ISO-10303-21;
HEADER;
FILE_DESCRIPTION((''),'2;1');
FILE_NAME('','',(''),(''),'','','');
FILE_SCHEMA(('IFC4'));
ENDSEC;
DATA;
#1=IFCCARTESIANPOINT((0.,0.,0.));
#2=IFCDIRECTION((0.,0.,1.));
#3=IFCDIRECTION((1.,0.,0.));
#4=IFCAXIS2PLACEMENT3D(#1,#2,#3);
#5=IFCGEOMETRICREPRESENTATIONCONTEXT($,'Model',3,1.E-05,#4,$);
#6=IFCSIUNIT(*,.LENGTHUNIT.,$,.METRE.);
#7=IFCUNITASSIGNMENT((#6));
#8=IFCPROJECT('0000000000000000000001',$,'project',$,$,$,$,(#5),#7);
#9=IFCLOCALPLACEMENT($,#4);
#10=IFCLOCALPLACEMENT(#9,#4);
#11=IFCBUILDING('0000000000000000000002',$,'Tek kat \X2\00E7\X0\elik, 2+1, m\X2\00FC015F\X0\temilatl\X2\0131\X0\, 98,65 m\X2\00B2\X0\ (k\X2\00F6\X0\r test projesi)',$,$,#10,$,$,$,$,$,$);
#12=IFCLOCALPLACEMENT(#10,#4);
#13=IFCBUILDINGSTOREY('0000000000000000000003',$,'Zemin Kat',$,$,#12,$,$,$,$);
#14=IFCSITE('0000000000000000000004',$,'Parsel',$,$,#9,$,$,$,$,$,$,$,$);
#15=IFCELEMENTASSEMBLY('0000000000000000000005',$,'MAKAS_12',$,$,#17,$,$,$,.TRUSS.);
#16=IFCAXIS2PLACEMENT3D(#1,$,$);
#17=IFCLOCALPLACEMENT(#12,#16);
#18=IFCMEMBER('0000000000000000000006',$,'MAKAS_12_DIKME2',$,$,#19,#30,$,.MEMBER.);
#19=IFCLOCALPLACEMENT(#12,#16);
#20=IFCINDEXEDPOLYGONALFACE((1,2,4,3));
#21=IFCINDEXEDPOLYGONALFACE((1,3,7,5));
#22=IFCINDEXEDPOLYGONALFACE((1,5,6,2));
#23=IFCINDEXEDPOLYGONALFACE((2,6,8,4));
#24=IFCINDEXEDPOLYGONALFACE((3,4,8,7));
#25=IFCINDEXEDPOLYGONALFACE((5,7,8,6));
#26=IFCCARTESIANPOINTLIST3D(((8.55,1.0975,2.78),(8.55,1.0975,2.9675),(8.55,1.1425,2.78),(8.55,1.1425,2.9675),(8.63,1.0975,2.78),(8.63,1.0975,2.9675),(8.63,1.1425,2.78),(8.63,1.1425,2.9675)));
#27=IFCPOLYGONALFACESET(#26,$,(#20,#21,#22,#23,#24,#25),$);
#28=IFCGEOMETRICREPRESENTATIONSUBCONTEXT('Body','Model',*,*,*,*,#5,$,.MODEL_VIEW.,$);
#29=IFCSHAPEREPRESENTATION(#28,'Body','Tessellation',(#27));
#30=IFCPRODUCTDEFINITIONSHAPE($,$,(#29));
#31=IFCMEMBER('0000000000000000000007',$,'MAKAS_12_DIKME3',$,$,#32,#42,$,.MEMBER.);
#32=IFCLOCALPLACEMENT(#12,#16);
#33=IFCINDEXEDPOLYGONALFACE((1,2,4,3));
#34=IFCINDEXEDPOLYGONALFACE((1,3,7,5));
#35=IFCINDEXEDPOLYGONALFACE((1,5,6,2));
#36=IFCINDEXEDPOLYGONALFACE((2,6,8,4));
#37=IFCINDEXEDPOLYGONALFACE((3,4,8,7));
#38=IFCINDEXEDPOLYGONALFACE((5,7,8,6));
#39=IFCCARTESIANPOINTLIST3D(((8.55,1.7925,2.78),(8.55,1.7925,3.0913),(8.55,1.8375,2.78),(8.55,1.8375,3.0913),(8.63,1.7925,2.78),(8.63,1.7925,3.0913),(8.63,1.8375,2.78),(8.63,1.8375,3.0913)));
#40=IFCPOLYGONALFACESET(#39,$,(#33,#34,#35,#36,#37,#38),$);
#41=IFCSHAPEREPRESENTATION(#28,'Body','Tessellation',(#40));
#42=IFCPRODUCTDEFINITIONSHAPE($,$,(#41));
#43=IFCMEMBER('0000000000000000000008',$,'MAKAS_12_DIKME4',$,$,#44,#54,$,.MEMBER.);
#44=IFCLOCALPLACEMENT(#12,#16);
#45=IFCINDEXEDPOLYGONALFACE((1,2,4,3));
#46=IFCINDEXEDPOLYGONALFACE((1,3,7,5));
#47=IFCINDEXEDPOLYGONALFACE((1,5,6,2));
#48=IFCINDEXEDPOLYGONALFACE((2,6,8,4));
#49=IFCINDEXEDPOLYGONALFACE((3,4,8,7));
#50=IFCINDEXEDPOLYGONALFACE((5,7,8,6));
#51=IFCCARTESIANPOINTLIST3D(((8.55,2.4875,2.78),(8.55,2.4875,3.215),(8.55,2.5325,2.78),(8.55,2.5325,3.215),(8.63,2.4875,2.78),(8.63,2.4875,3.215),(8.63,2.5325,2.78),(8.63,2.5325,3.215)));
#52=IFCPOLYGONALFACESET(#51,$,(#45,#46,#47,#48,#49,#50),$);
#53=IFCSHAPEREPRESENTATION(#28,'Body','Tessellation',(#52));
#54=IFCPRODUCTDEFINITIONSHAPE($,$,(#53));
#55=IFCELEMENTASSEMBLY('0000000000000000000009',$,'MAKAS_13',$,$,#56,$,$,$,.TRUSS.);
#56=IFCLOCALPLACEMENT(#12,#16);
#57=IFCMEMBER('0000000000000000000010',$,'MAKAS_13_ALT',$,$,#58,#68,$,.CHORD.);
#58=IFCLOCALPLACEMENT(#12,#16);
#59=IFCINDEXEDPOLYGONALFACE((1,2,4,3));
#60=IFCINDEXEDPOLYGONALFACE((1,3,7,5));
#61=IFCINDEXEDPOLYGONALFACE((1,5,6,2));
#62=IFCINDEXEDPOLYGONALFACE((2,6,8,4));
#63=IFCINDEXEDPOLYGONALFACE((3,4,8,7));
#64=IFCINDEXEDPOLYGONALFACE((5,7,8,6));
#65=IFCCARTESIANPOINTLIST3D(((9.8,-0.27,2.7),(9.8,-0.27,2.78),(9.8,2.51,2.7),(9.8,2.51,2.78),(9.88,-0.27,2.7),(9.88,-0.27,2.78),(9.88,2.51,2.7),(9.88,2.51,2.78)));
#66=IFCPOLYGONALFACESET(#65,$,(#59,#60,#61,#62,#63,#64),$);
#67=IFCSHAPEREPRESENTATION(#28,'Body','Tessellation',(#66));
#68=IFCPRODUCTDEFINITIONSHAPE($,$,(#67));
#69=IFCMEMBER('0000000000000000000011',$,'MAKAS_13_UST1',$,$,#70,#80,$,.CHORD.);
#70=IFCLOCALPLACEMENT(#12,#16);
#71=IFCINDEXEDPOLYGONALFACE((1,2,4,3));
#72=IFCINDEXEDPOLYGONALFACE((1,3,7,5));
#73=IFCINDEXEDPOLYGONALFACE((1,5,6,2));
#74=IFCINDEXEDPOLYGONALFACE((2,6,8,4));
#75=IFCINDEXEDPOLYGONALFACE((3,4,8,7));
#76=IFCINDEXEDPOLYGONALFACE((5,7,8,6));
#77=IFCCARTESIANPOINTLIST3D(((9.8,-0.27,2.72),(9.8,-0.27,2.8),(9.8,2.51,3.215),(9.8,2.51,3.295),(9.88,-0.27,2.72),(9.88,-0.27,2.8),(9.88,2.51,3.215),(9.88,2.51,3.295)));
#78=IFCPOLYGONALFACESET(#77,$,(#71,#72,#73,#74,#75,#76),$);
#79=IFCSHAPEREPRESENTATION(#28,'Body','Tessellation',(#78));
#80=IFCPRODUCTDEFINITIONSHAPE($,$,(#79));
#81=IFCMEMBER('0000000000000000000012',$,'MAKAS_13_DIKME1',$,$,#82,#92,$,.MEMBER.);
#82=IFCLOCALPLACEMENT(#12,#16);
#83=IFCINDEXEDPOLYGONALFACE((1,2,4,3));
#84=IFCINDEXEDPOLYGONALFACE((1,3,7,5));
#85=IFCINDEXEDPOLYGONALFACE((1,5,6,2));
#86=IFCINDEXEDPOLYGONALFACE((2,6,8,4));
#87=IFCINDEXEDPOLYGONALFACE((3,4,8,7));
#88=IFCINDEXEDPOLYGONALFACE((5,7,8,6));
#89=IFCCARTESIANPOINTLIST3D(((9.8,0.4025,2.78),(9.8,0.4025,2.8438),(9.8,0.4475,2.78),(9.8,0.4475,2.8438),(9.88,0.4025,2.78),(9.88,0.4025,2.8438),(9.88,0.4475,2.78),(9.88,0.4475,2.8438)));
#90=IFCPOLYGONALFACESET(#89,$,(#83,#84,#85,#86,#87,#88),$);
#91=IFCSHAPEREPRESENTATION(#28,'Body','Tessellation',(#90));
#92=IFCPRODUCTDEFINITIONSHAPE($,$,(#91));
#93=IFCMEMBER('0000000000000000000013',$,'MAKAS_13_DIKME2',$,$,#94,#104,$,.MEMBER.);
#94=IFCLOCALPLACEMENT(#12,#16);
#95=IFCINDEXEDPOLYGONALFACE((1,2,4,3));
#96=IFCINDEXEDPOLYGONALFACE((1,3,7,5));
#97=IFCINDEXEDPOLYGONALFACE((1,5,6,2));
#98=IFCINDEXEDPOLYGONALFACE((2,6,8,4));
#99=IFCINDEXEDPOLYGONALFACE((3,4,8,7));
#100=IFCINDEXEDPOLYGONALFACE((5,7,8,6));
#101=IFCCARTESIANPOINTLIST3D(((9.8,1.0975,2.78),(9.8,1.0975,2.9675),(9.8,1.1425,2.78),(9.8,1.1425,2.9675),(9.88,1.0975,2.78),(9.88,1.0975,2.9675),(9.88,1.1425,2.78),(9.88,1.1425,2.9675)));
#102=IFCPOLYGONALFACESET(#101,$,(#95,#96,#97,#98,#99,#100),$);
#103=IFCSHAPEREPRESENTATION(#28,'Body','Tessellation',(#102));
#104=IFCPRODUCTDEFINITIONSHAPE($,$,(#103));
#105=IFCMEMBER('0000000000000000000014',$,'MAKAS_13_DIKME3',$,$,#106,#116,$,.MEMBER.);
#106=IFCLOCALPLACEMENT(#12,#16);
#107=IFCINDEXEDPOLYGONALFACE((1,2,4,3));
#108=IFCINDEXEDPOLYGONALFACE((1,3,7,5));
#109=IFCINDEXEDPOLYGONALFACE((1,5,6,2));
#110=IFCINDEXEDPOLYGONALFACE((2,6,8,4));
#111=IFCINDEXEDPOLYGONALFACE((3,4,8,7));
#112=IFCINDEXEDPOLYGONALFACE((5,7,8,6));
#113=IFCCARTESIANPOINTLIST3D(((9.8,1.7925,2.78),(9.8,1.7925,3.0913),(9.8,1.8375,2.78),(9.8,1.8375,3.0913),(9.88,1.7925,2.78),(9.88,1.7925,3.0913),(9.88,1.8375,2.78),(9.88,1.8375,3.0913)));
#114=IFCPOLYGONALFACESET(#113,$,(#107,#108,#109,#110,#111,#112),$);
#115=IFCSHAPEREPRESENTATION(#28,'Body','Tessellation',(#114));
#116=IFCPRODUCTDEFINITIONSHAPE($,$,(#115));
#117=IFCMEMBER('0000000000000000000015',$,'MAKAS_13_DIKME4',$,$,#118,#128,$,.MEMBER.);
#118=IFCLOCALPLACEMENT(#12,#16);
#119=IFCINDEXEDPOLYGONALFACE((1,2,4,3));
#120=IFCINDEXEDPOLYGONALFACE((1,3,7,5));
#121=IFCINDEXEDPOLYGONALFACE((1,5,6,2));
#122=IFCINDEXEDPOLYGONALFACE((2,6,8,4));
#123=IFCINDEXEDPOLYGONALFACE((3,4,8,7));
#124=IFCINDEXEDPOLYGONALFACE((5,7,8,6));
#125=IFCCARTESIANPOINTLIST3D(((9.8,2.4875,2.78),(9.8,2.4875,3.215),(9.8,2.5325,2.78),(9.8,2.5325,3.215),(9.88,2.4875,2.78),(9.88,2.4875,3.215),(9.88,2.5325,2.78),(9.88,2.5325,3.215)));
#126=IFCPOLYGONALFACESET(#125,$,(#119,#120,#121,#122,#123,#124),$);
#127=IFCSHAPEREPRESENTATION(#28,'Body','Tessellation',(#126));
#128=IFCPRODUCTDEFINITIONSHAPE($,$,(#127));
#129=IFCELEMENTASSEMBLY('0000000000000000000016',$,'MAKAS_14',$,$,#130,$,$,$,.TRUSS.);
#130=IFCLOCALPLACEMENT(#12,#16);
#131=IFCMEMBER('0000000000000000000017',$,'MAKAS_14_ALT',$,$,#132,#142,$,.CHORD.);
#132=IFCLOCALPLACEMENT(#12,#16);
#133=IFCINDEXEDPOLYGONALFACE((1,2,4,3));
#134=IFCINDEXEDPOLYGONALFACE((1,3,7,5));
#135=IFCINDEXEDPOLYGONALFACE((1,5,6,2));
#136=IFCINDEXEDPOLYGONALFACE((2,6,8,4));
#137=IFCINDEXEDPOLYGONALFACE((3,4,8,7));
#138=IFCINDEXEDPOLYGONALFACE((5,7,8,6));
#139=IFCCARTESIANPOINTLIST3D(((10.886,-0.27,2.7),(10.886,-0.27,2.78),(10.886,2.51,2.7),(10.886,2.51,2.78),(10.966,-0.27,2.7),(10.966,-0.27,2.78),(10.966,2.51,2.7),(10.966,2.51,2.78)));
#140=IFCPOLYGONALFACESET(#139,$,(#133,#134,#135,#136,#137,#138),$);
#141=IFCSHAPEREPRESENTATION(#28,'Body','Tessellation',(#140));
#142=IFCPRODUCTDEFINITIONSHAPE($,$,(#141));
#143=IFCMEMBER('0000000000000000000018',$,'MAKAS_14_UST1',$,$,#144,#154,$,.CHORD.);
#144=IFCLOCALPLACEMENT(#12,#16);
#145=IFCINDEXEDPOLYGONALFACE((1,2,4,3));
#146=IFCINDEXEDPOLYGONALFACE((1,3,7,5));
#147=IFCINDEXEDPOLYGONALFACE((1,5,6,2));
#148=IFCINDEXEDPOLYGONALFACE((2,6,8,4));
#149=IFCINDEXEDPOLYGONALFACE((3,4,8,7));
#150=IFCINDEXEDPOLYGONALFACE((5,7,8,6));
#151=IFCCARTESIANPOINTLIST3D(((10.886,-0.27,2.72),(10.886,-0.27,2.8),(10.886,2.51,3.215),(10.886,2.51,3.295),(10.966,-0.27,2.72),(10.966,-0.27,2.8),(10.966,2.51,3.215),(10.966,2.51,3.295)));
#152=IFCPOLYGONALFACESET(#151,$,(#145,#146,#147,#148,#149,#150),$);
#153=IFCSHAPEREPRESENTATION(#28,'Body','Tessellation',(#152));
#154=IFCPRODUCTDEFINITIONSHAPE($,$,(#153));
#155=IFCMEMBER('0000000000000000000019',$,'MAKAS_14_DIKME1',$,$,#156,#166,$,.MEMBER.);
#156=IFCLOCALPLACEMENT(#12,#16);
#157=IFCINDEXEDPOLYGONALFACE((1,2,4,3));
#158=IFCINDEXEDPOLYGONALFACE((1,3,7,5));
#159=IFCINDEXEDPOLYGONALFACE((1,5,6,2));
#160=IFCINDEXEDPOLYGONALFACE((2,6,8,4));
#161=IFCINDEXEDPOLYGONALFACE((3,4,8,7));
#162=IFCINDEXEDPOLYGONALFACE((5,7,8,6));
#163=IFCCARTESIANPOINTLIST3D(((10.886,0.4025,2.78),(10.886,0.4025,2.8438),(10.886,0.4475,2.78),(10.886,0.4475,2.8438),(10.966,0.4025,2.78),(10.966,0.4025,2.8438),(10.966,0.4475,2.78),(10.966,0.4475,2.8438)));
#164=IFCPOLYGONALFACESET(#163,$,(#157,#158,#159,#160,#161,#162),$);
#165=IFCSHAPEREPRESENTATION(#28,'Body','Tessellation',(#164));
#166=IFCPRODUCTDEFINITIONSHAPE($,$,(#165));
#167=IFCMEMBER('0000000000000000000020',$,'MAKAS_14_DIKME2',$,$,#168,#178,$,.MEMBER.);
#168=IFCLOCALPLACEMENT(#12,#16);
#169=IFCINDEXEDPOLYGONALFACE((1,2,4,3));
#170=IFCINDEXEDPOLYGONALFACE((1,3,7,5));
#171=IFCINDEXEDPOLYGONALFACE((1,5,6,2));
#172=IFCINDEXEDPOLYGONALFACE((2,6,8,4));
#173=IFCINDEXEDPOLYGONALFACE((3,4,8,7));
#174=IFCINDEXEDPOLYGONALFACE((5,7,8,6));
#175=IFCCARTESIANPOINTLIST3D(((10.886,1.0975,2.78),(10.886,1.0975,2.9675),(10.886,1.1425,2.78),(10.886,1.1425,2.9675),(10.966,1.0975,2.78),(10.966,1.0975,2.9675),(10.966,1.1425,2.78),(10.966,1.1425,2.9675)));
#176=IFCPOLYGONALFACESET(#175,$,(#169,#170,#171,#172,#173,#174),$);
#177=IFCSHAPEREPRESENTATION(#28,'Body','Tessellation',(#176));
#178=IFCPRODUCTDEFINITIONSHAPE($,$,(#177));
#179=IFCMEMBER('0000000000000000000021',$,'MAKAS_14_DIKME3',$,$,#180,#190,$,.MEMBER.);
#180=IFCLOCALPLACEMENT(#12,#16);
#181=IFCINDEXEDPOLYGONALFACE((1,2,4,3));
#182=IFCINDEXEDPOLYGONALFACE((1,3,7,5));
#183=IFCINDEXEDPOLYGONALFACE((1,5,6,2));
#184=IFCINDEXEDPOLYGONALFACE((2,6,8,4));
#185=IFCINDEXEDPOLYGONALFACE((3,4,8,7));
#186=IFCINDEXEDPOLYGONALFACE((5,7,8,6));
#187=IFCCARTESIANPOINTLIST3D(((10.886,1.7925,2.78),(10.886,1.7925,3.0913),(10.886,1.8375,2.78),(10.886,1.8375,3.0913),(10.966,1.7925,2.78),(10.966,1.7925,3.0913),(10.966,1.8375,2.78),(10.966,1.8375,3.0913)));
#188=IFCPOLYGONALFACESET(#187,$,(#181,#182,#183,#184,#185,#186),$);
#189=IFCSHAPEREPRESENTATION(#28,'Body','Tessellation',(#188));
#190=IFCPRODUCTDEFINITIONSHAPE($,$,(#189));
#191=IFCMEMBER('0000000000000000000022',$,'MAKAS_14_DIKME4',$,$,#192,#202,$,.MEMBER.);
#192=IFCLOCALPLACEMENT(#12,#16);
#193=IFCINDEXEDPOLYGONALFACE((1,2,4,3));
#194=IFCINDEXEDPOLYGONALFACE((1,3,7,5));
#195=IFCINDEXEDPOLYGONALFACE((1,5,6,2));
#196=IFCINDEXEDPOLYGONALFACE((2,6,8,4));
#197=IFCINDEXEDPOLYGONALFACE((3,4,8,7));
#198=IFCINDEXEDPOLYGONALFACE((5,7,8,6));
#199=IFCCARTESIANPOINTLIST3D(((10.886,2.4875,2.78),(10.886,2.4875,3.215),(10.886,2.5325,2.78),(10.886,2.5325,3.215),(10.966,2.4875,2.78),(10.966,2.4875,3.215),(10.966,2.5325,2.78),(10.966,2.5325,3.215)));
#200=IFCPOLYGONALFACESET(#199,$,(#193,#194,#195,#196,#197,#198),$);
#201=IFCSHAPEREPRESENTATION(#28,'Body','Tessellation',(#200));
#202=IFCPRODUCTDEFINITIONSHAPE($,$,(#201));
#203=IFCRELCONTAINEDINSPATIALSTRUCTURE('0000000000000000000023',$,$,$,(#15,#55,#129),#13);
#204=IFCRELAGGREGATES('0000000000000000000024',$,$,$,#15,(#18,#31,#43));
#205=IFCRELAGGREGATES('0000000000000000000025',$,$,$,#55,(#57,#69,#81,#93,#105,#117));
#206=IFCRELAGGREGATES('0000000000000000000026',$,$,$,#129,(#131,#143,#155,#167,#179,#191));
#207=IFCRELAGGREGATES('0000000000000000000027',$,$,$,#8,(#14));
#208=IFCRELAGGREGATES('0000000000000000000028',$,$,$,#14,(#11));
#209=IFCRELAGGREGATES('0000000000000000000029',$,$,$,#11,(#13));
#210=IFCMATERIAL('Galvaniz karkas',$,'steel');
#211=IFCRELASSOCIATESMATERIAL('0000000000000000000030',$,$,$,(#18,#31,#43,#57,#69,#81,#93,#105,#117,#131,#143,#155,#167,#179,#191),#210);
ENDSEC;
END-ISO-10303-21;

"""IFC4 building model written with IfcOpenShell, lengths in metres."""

from ifc_helpers import new_model, si_unit, frame, origin_with_axes, place, context, subcontext, project, spatial, line, indexed_curve, outline, extrude, material, element, aggregate, save


model = new_model("IFC4")

# Units and contexts
model_context = context("Model", 3, precision=1e-05, world=origin_with_axes())
body_context = subcontext(model_context, "Body", "Model", "MODEL_VIEW")
ifc_project = project(units=[si_unit("LENGTHUNIT", "METRE")], contexts=[model_context])

# Site, building, storey
site_placement = place(None, origin_with_axes())
site = spatial("IfcSite", under=ifc_project, at=site_placement, Name="Parsel")
building_placement = place(site_placement, origin_with_axes())
building = spatial("IfcBuilding", under=site, at=building_placement, Name="Tek kat çelik, 2+1, müştemilatlı, 98,65 m² (kör test projesi)")
storey_placement = place(building_placement, origin_with_axes())
storey = spatial("IfcBuildingStorey", under=building, at=storey_placement, Name="Zemin Kat")

# Element assemblies, members
ifc_material = material(Name="Galvaniz karkas", Category="steel")
assembly_1_placement = place(storey_placement, origin_with_axes())
assembly_1 = element("IfcElementAssembly", 1, at=assembly_1_placement, inside=storey, Name="MAKAS_12", PredefinedType="TRUSS")
member_1_placement = place(assembly_1_placement, origin_with_axes())
member_1 = element("IfcMember", 2, at=member_1_placement, material=ifc_material, Name="MAKAS_12_DIKME2", PredefinedType="MEMBER", context=body_context, shape_type="SweptSolid", body=[
    extrude(outline(indexed_curve([(1.0975, 2.78), (1.1425, 2.78), (1.1425, 2.9675), (1.0975, 2.9675)], segments=[line(1, 2, 3, 4, 1)])), frame((8.55, 0.0, 0.0), z_axis=(1.0, 0.0, 0.0), x_axis=(0.0, 1.0, 0.0)), (0.0, 0.0, 1.0), 0.08),
])
member_2_placement = place(assembly_1_placement, origin_with_axes())
member_2 = element("IfcMember", 3, at=member_2_placement, material=ifc_material, Name="MAKAS_12_DIKME3", PredefinedType="MEMBER", context=body_context, shape_type="SweptSolid", body=[
    extrude(outline(indexed_curve([(1.7925, 2.78), (1.8375, 2.78), (1.8375, 3.0913), (1.7925, 3.0913)], segments=[line(1, 2, 3, 4, 1)])), frame((8.55, 0.0, 0.0), z_axis=(1.0, 0.0, 0.0), x_axis=(0.0, 1.0, 0.0)), (0.0, 0.0, 1.0), 0.08),
])
member_3_placement = place(assembly_1_placement, origin_with_axes())
member_3 = element("IfcMember", 4, at=member_3_placement, material=ifc_material, Name="MAKAS_12_DIKME4", PredefinedType="MEMBER", context=body_context, shape_type="SweptSolid", body=[
    extrude(outline(indexed_curve([(2.4875, 2.78), (2.5325, 2.78), (2.5325, 3.215), (2.4875, 3.215)], segments=[line(1, 2, 3, 4, 1)])), frame((8.55, 0.0, 0.0), z_axis=(1.0, 0.0, 0.0), x_axis=(0.0, 1.0, 0.0)), (0.0, 0.0, 1.0), 0.08),
])
aggregate(assembly_1, [member_1, member_2, member_3])
assembly_2_placement = place(storey_placement, origin_with_axes())
assembly_2 = element("IfcElementAssembly", 5, at=assembly_2_placement, inside=storey, Name="MAKAS_13", PredefinedType="TRUSS")
member_4_placement = place(assembly_2_placement, origin_with_axes())
member_4 = element("IfcMember", 6, at=member_4_placement, material=ifc_material, Name="MAKAS_13_ALT", PredefinedType="CHORD", context=body_context, shape_type="SweptSolid", body=[
    extrude(outline(indexed_curve([(-0.27, 2.7), (2.51, 2.7), (2.51, 2.78), (-0.27, 2.78)], segments=[line(1, 2, 3, 4, 1)])), frame((9.8, 0.0, 0.0), z_axis=(1.0, 0.0, 0.0), x_axis=(0.0, 1.0, 0.0)), (0.0, 0.0, 1.0), 0.08),
])
member_5_placement = place(assembly_2_placement, origin_with_axes())
member_5 = element("IfcMember", 7, at=member_5_placement, material=ifc_material, Name="MAKAS_13_UST1", PredefinedType="CHORD", context=body_context, shape_type="SweptSolid", body=[
    extrude(outline(indexed_curve([(-0.27, 2.72), (2.51, 3.215), (2.51, 3.295), (-0.27, 2.8)], segments=[line(1, 2, 3, 4, 1)])), frame((9.8, 0.0, 0.0), z_axis=(1.0, 0.0, 0.0), x_axis=(0.0, 1.0, 0.0)), (0.0, 0.0, 1.0), 0.08),
])
member_6_placement = place(assembly_2_placement, origin_with_axes())
member_6 = element("IfcMember", 8, at=member_6_placement, material=ifc_material, Name="MAKAS_13_DIKME1", PredefinedType="MEMBER", context=body_context, shape_type="SweptSolid", body=[
    extrude(outline(indexed_curve([(0.4025, 2.78), (0.4475, 2.78), (0.4475, 2.8438), (0.4025, 2.8438)], segments=[line(1, 2, 3, 4, 1)])), frame((9.8, 0.0, 0.0), z_axis=(1.0, 0.0, 0.0), x_axis=(0.0, 1.0, 0.0)), (0.0, 0.0, 1.0), 0.08),
])
member_7_placement = place(assembly_2_placement, origin_with_axes())
member_7 = element("IfcMember", 9, at=member_7_placement, material=ifc_material, Name="MAKAS_13_DIKME2", PredefinedType="MEMBER", context=body_context, shape_type="SweptSolid", body=[
    extrude(outline(indexed_curve([(1.0975, 2.78), (1.1425, 2.78), (1.1425, 2.9675), (1.0975, 2.9675)], segments=[line(1, 2, 3, 4, 1)])), frame((9.8, 0.0, 0.0), z_axis=(1.0, 0.0, 0.0), x_axis=(0.0, 1.0, 0.0)), (0.0, 0.0, 1.0), 0.08),
])
member_8_placement = place(assembly_2_placement, origin_with_axes())
member_8 = element("IfcMember", 10, at=member_8_placement, material=ifc_material, Name="MAKAS_13_DIKME3", PredefinedType="MEMBER", context=body_context, shape_type="SweptSolid", body=[
    extrude(outline(indexed_curve([(1.7925, 2.78), (1.8375, 2.78), (1.8375, 3.0913), (1.7925, 3.0913)], segments=[line(1, 2, 3, 4, 1)])), frame((9.8, 0.0, 0.0), z_axis=(1.0, 0.0, 0.0), x_axis=(0.0, 1.0, 0.0)), (0.0, 0.0, 1.0), 0.08),
])
member_9_placement = place(assembly_2_placement, origin_with_axes())
member_9 = element("IfcMember", 11, at=member_9_placement, material=ifc_material, Name="MAKAS_13_DIKME4", PredefinedType="MEMBER", context=body_context, shape_type="SweptSolid", body=[
    extrude(outline(indexed_curve([(2.4875, 2.78), (2.5325, 2.78), (2.5325, 3.215), (2.4875, 3.215)], segments=[line(1, 2, 3, 4, 1)])), frame((9.8, 0.0, 0.0), z_axis=(1.0, 0.0, 0.0), x_axis=(0.0, 1.0, 0.0)), (0.0, 0.0, 1.0), 0.08),
])
aggregate(assembly_2, [member_4, member_5, member_6, member_7, member_8, member_9])
assembly_3_placement = place(storey_placement, origin_with_axes())
assembly_3 = element("IfcElementAssembly", 12, at=assembly_3_placement, inside=storey, Name="MAKAS_14", PredefinedType="TRUSS")
member_10_placement = place(assembly_3_placement, origin_with_axes())
member_10 = element("IfcMember", 13, at=member_10_placement, material=ifc_material, Name="MAKAS_14_ALT", PredefinedType="CHORD", context=body_context, shape_type="SweptSolid", body=[
    extrude(outline(indexed_curve([(-0.27, 2.7), (2.51, 2.7), (2.51, 2.78), (-0.27, 2.78)], segments=[line(1, 2, 3, 4, 1)])), frame((10.886, 0.0, 0.0), z_axis=(1.0, 0.0, 0.0), x_axis=(0.0, 1.0, 0.0)), (0.0, 0.0, 1.0), 0.08),
])
member_11_placement = place(assembly_3_placement, origin_with_axes())
member_11 = element("IfcMember", 14, at=member_11_placement, material=ifc_material, Name="MAKAS_14_UST1", PredefinedType="CHORD", context=body_context, shape_type="SweptSolid", body=[
    extrude(outline(indexed_curve([(-0.27, 2.72), (2.51, 3.215), (2.51, 3.295), (-0.27, 2.8)], segments=[line(1, 2, 3, 4, 1)])), frame((10.886, 0.0, 0.0), z_axis=(1.0, 0.0, 0.0), x_axis=(0.0, 1.0, 0.0)), (0.0, 0.0, 1.0), 0.08),
])
member_12_placement = place(assembly_3_placement, origin_with_axes())
member_12 = element("IfcMember", 15, at=member_12_placement, material=ifc_material, Name="MAKAS_14_DIKME1", PredefinedType="MEMBER", context=body_context, shape_type="SweptSolid", body=[
    extrude(outline(indexed_curve([(0.4025, 2.78), (0.4475, 2.78), (0.4475, 2.8438), (0.4025, 2.8438)], segments=[line(1, 2, 3, 4, 1)])), frame((10.886, 0.0, 0.0), z_axis=(1.0, 0.0, 0.0), x_axis=(0.0, 1.0, 0.0)), (0.0, 0.0, 1.0), 0.08),
])
member_13_placement = place(assembly_3_placement, origin_with_axes())
member_13 = element("IfcMember", 16, at=member_13_placement, material=ifc_material, Name="MAKAS_14_DIKME2", PredefinedType="MEMBER", context=body_context, shape_type="SweptSolid", body=[
    extrude(outline(indexed_curve([(1.0975, 2.78), (1.1425, 2.78), (1.1425, 2.9675), (1.0975, 2.9675)], segments=[line(1, 2, 3, 4, 1)])), frame((10.886, 0.0, 0.0), z_axis=(1.0, 0.0, 0.0), x_axis=(0.0, 1.0, 0.0)), (0.0, 0.0, 1.0), 0.08),
])
member_14_placement = place(assembly_3_placement, origin_with_axes())
member_14 = element("IfcMember", 17, at=member_14_placement, material=ifc_material, Name="MAKAS_14_DIKME3", PredefinedType="MEMBER", context=body_context, shape_type="SweptSolid", body=[
    extrude(outline(indexed_curve([(1.7925, 2.78), (1.8375, 2.78), (1.8375, 3.0913), (1.7925, 3.0913)], segments=[line(1, 2, 3, 4, 1)])), frame((10.886, 0.0, 0.0), z_axis=(1.0, 0.0, 0.0), x_axis=(0.0, 1.0, 0.0)), (0.0, 0.0, 1.0), 0.08),
])
member_15_placement = place(assembly_3_placement, origin_with_axes())
member_15 = element("IfcMember", 18, at=member_15_placement, material=ifc_material, Name="MAKAS_14_DIKME4", PredefinedType="MEMBER", context=body_context, shape_type="SweptSolid", body=[
    extrude(outline(indexed_curve([(2.4875, 2.78), (2.5325, 2.78), (2.5325, 3.215), (2.4875, 3.215)], segments=[line(1, 2, 3, 4, 1)])), frame((10.886, 0.0, 0.0), z_axis=(1.0, 0.0, 0.0), x_axis=(0.0, 1.0, 0.0)), (0.0, 0.0, 1.0), 0.08),
])
aggregate(assembly_3, [member_10, member_11, member_12, member_13, member_14, member_15])

save(model, "model.ifc")
